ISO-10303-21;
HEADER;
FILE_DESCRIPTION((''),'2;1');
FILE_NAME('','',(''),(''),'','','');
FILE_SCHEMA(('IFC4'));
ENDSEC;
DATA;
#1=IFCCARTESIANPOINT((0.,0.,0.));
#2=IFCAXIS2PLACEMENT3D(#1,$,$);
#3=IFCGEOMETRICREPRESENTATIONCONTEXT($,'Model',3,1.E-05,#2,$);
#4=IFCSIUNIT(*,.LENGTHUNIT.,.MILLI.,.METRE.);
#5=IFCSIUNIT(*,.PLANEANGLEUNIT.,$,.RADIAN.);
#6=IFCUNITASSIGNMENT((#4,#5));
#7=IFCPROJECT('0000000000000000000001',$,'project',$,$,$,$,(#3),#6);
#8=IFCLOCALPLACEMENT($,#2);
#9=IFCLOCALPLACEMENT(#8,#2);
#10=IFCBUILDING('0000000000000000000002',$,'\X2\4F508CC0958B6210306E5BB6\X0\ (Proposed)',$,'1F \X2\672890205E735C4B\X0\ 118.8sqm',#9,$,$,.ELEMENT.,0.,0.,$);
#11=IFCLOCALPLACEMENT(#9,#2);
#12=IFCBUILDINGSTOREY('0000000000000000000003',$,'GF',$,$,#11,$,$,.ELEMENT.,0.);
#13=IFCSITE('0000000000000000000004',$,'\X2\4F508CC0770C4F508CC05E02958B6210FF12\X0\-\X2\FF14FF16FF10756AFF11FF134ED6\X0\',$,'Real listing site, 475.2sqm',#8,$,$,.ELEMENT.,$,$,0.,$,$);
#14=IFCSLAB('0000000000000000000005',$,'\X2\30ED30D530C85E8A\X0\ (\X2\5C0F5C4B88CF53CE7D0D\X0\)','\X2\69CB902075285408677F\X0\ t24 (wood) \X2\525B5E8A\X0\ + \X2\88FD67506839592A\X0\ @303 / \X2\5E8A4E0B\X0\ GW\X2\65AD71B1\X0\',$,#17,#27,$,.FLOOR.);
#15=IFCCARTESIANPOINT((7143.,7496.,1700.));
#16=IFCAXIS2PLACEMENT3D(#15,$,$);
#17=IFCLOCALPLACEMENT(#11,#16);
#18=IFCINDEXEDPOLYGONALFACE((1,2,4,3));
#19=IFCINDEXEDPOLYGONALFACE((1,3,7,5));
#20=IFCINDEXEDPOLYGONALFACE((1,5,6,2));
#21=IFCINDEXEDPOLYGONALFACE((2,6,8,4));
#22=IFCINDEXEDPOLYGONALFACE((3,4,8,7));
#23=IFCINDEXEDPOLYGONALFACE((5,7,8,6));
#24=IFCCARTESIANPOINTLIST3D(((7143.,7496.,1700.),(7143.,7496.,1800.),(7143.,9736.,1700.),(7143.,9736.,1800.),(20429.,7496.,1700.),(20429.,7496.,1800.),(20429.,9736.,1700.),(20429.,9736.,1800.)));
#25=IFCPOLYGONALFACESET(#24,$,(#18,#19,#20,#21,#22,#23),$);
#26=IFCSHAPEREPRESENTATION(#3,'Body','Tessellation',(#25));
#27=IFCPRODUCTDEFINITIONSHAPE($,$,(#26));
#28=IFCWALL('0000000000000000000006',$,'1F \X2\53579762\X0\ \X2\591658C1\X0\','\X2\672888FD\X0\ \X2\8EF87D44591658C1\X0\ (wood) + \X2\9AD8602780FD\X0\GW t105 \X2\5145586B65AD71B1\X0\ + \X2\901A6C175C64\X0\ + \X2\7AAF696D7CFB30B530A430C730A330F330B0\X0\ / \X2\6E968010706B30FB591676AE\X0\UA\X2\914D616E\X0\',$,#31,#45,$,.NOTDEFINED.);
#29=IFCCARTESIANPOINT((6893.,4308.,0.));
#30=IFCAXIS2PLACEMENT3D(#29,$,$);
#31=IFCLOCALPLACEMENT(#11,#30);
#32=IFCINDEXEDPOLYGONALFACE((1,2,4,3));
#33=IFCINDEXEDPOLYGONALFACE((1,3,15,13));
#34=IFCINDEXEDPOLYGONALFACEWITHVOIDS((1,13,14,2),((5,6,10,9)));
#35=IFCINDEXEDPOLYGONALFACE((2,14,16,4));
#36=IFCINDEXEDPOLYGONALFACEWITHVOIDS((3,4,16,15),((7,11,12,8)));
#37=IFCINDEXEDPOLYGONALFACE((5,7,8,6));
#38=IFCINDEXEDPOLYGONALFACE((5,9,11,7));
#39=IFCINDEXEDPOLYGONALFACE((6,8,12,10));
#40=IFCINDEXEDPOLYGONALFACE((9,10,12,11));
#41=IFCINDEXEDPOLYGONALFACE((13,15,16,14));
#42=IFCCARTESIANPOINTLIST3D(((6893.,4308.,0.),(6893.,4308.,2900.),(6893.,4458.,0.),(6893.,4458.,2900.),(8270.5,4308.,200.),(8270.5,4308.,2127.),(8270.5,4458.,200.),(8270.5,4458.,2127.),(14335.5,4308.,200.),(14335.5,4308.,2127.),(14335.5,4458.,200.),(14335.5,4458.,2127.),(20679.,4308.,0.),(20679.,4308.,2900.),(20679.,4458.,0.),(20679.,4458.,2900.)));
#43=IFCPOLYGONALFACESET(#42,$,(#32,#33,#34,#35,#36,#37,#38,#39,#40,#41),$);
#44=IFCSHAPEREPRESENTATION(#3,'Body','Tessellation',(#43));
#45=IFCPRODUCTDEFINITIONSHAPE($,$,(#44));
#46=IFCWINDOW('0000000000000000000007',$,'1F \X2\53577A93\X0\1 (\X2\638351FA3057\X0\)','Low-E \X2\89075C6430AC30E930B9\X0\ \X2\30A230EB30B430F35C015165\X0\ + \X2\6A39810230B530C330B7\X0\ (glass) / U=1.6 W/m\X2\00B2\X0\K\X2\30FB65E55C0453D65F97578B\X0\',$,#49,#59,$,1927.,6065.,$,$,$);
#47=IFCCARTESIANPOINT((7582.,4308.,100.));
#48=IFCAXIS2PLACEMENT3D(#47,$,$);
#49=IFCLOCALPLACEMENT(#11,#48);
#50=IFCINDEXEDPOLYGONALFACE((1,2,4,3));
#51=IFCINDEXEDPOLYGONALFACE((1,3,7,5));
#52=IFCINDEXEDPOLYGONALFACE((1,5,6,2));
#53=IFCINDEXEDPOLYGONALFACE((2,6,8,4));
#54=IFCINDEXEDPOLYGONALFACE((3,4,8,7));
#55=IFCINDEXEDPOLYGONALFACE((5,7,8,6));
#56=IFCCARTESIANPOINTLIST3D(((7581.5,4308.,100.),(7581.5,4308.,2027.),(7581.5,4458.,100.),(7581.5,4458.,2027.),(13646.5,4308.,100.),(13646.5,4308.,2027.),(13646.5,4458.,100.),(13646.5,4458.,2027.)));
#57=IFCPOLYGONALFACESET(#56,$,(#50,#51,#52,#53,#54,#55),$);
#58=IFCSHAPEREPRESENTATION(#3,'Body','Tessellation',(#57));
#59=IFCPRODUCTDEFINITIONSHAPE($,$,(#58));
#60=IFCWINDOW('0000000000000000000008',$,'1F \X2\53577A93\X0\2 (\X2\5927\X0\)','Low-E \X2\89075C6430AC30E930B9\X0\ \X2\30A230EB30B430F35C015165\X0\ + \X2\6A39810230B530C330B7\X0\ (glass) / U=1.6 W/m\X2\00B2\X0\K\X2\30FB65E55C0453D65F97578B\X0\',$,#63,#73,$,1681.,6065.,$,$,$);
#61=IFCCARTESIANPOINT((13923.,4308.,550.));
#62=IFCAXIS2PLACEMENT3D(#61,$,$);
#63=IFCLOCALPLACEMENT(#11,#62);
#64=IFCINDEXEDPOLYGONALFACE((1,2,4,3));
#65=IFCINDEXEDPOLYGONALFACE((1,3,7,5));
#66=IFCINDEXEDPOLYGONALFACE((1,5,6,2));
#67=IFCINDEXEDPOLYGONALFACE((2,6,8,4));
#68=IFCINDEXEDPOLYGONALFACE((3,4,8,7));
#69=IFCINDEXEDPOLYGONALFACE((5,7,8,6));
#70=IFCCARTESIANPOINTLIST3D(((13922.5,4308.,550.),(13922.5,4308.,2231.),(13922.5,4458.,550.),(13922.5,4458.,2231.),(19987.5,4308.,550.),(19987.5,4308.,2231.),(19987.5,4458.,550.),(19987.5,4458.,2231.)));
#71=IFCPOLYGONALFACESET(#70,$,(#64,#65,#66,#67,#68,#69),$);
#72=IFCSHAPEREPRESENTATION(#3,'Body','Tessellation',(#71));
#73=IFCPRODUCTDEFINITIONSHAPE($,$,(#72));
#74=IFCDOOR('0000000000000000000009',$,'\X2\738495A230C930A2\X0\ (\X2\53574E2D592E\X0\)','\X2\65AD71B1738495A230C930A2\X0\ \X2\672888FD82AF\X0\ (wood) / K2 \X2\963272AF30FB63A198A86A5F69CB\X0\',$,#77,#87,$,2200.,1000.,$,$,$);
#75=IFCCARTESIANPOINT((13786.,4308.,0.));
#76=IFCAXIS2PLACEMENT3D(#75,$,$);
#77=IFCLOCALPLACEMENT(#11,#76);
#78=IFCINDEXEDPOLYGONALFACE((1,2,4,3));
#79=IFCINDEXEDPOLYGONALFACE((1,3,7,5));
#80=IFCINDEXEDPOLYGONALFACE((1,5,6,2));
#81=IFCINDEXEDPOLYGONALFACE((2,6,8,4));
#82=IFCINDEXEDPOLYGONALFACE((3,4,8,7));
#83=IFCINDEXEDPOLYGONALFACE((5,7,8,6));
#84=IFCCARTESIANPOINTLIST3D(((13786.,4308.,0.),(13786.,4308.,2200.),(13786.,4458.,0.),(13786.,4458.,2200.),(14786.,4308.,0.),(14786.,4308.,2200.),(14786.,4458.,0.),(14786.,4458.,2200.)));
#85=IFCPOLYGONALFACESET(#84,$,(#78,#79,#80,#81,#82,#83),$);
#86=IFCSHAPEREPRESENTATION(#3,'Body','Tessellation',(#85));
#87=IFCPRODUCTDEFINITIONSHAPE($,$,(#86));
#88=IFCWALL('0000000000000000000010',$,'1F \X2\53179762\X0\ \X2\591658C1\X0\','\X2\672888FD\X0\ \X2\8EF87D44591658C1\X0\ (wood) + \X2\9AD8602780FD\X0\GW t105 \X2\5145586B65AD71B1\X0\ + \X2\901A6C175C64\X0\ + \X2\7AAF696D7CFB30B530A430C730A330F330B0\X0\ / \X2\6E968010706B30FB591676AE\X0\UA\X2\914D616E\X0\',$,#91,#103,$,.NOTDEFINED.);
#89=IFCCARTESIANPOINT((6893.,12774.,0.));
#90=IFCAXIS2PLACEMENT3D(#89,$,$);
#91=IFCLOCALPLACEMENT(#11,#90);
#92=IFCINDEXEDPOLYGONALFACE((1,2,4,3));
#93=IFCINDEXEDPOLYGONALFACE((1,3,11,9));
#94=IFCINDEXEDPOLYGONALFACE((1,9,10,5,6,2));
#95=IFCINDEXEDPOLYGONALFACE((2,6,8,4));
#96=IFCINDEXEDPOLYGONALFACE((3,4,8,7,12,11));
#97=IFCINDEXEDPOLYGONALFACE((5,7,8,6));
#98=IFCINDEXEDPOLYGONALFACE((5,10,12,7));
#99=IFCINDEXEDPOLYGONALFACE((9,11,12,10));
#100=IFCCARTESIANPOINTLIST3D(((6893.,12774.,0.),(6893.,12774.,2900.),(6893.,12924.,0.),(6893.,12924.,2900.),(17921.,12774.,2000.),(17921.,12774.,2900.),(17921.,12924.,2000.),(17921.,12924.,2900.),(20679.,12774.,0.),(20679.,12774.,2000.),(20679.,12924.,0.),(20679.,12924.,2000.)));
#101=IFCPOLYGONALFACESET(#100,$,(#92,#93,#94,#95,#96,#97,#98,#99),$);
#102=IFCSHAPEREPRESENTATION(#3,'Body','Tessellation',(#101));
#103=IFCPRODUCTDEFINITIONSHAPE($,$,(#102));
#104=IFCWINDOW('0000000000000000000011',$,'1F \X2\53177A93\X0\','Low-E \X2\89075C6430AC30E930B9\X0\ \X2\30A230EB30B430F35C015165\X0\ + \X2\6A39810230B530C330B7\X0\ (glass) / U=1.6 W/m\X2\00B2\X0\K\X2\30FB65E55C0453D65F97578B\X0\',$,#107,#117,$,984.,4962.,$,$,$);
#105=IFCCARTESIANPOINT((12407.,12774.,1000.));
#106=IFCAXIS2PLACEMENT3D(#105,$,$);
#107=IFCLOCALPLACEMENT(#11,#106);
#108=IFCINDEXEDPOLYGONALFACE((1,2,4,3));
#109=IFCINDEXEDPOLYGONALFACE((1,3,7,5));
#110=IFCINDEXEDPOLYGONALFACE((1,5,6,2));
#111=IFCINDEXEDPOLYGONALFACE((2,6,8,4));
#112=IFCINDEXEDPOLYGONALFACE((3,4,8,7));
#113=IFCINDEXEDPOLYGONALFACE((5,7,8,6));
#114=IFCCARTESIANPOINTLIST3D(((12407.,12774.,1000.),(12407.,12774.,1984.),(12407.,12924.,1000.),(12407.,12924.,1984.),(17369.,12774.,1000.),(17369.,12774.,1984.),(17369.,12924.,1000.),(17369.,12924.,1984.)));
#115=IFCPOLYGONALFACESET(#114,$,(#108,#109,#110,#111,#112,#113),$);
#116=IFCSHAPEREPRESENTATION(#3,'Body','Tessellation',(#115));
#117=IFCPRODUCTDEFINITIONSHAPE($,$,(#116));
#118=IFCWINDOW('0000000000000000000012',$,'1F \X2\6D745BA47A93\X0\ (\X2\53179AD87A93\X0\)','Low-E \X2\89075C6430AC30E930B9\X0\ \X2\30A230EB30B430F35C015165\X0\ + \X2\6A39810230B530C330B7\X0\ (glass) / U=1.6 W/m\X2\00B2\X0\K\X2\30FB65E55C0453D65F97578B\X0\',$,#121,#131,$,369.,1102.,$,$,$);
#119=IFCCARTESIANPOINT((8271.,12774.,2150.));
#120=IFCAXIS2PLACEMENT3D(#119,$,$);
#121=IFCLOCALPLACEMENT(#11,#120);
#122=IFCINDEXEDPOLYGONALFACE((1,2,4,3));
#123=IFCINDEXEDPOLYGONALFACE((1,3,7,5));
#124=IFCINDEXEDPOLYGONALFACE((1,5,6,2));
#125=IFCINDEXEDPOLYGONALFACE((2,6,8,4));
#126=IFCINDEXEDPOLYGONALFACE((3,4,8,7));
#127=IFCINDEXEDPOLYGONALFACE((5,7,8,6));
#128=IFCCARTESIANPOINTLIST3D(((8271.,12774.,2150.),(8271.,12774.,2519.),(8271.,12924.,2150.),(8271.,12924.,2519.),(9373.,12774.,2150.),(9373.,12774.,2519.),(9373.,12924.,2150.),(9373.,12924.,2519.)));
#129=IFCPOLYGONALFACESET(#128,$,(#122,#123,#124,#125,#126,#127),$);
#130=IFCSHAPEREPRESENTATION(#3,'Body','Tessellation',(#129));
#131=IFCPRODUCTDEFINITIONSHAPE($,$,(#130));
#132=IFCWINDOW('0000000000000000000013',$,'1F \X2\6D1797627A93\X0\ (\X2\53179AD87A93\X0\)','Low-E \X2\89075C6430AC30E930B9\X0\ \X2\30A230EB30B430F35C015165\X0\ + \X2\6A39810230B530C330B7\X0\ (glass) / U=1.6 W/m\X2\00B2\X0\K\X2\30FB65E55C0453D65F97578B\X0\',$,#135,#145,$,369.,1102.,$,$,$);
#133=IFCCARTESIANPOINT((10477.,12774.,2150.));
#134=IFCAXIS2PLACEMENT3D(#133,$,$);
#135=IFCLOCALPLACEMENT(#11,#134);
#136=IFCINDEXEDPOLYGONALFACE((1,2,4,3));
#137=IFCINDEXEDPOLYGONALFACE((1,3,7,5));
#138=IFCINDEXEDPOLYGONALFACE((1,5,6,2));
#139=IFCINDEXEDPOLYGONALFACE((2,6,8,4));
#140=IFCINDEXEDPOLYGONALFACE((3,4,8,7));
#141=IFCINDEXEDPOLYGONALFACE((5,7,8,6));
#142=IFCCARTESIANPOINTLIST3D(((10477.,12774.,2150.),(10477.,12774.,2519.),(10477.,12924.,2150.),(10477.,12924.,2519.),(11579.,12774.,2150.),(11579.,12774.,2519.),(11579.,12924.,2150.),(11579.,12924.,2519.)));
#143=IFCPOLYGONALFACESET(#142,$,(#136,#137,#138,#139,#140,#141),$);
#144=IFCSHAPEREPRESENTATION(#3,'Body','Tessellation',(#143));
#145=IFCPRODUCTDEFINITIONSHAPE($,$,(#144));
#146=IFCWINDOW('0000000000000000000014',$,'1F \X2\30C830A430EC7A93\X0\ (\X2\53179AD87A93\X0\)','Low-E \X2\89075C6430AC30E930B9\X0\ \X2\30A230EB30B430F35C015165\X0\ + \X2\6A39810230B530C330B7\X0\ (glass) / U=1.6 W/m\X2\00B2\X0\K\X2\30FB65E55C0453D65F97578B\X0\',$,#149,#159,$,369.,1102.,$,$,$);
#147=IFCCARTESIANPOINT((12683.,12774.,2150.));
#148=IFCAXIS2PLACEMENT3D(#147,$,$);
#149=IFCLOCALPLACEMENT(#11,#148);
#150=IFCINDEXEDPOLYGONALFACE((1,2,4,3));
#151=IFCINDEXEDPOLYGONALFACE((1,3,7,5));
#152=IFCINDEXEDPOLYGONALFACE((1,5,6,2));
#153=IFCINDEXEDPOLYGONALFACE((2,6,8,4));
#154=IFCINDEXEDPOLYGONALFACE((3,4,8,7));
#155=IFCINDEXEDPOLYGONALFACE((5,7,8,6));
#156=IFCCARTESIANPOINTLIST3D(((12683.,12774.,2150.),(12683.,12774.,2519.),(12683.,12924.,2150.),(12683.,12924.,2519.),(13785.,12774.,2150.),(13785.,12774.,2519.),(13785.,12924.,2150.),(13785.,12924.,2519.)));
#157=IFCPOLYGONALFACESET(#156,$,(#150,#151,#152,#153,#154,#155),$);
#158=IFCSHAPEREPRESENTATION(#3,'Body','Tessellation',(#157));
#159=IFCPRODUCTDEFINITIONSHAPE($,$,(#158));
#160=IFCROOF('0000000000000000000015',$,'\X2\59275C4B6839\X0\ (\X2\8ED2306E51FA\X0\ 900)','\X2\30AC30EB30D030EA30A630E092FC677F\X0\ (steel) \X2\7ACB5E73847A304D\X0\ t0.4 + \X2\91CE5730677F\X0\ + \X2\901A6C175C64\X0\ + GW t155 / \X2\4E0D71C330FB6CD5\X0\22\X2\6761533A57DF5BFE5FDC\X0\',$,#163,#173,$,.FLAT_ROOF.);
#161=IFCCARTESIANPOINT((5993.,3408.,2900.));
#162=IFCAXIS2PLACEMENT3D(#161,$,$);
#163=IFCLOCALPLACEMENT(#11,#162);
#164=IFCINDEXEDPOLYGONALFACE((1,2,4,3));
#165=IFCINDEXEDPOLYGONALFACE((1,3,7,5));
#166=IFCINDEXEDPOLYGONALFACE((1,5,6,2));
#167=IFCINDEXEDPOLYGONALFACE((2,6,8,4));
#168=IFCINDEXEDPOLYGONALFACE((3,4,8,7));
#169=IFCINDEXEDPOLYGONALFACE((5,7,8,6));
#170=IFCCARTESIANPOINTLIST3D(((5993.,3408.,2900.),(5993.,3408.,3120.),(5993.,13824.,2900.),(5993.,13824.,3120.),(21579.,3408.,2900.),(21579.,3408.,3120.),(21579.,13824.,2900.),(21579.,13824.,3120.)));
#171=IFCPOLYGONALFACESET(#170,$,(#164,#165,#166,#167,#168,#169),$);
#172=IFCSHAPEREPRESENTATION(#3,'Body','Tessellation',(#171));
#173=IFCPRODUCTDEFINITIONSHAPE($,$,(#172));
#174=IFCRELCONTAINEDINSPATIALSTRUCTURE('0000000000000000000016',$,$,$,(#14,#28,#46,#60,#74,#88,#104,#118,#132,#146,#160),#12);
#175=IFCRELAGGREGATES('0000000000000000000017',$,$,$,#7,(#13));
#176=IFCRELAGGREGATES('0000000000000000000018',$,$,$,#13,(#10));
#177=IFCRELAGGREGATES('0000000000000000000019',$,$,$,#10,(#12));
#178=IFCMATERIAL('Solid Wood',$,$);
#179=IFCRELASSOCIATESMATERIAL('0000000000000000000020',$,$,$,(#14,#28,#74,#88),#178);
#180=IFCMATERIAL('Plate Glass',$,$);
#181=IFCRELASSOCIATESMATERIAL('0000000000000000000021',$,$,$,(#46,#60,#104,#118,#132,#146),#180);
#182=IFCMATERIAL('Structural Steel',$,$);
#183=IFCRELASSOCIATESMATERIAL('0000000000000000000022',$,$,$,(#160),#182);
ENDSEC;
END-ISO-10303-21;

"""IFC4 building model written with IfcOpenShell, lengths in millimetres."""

from ifc_helpers import new_model, si_unit, frame, frame_2d, origin, place, context, project, spatial, rectangle, extrude, material, element, fill, save


model = new_model("IFC4")

# Units and contexts
model_context = context("Model", 3, precision=1e-05, world=origin())
ifc_project = project(units=[si_unit("LENGTHUNIT", "METRE", prefix="MILLI"), si_unit("PLANEANGLEUNIT", "RADIAN")], contexts=[model_context])

# Site, building, storey
site_placement = place(None, origin())
site = spatial("IfcSite", under=ifc_project, at=site_placement, Name="佐賀県佐賀市開成２-４６０番１３他", ObjectType="Real listing site, 475.2sqm", CompositionType="ELEMENT", RefElevation=0.0)
building_placement = place(site_placement, origin())
building = spatial("IfcBuilding", under=site, at=building_placement, Name="佐賀開成の家 (Proposed)", ObjectType="1F 木造平屋 118.8sqm", CompositionType="ELEMENT", ElevationOfRefHeight=0.0, ElevationOfTerrain=0.0)
storey_placement = place(building_placement, origin())
storey = spatial("IfcBuildingStorey", under=building, at=storey_placement, Name="GF", CompositionType="ELEMENT", Elevation=0.0)

# Slab
ifc_material_1 = material(Name="Solid Wood")
slab_1_placement = place(storey_placement, frame((7143.0, 7496.0, 1700.0)))
element("IfcSlab", 1, at=slab_1_placement, inside=storey, material=ifc_material_1, Name="ロフト床 (小屋裏収納)", Description="構造用合板 t24 (wood) 剛床 + 製材根太 @303 / 床下 GW断熱", PredefinedType="FLOOR", context=model_context, shape_type="SweptSolid", body=[
    extrude(rectangle(XDim=13286.0, YDim=2240.0, at=frame_2d((6643.0, 1120.0))), frame((7143.0, 7496.0, 1700.0)), (0.0, 0.0, 1.0), 100.0),
])

# Wall, openings, windows, door
wall_1_placement = place(storey_placement, frame((6893.0, 4308.0, 0.0)))
wall_1 = element("IfcWall", 2, at=wall_1_placement, inside=storey, material=ifc_material_1, Name="1F 南面 外壁", Description="木製 軸組外壁 (wood) + 高性能GW t105 充填断熱 + 通気層 + 窯業系サイディング / 準耐火・外皮UA配慮", PredefinedType="NOTDEFINED", context=model_context, shape_type="SweptSolid", body=[
    extrude(rectangle(XDim=13786.0, YDim=150.0, at=frame_2d((6893.0, 75.0))), frame((6893.0, 4308.0, 0.0)), (0.0, 0.0, 1.0), 2900.0),
])
opening_1_placement = place(storey_placement, frame((7582.0, 4308.0, 100.0)))
opening_1 = element("IfcOpeningElement", 3, at=opening_1_placement, cuts=wall_1, PredefinedType="NOTDEFINED", context=model_context, shape_type="SweptSolid", body=[
    extrude(rectangle(XDim=6065.0, YDim=150.0, at=frame_2d((3032.0, 75.0))), frame((7582.0, 4308.0, 100.0)), (0.0, 0.0, 1.0), 1927.0),
])
opening_2_placement = place(storey_placement, frame((13923.0, 4308.0, 550.0)))
opening_2 = element("IfcOpeningElement", 4, at=opening_2_placement, cuts=wall_1, PredefinedType="NOTDEFINED", context=model_context, shape_type="SweptSolid", body=[
    extrude(rectangle(XDim=6065.0, YDim=150.0, at=frame_2d((3032.0, 75.0))), frame((13923.0, 4308.0, 550.0)), (0.0, 0.0, 1.0), 1681.0),
])
opening_3_placement = place(storey_placement, frame((13786.0, 4308.0, 0.0)))
opening_3 = element("IfcOpeningElement", 5, at=opening_3_placement, cuts=wall_1, PredefinedType="NOTDEFINED", context=model_context, shape_type="SweptSolid", body=[
    extrude(rectangle(XDim=1000.0, YDim=150.0, at=frame_2d((500.0, 75.0))), frame((13786.0, 4308.0, 0.0)), (0.0, 0.0, 1.0), 2200.0),
])
ifc_material_2 = material(Name="Plate Glass")
window_1_placement = place(storey_placement, frame((7582.0, 4308.0, 100.0)))
window_1 = element("IfcWindow", 6, at=window_1_placement, inside=storey, material=ifc_material_2, Name="1F 南窓1 (掃出し)", Description="Low-E 複層ガラス アルゴン封入 + 樹脂サッシ (glass) / U=1.6 W/m²K・日射取得型", OverallHeight=1927.0, OverallWidth=6065.0, context=model_context, shape_type="SweptSolid", body=[
    extrude(rectangle(XDim=6065.0, YDim=150.0, at=frame_2d((3032.0, 75.0))), frame((7582.0, 4308.0, 100.0)), (0.0, 0.0, 1.0), 1927.0),
])
fill(opening_1, window_1)
window_2_placement = place(storey_placement, frame((13923.0, 4308.0, 550.0)))
window_2 = element("IfcWindow", 7, at=window_2_placement, inside=storey, material=ifc_material_2, Name="1F 南窓2 (大)", Description="Low-E 複層ガラス アルゴン封入 + 樹脂サッシ (glass) / U=1.6 W/m²K・日射取得型", OverallHeight=1681.0, OverallWidth=6065.0, context=model_context, shape_type="SweptSolid", body=[
    extrude(rectangle(XDim=6065.0, YDim=150.0, at=frame_2d((3032.0, 75.0))), frame((13923.0, 4308.0, 550.0)), (0.0, 0.0, 1.0), 1681.0),
])
fill(opening_2, window_2)
door_1_placement = place(storey_placement, frame((13786.0, 4308.0, 0.0)))
door_1 = element("IfcDoor", 8, at=door_1_placement, inside=storey, material=ifc_material_1, Name="玄関ドア (南中央)", Description="断熱玄関ドア 木製芯 (wood) / K2 防犯・採風機構", OverallHeight=2200.0, OverallWidth=1000.0, context=model_context, shape_type="SweptSolid", body=[
    extrude(rectangle(XDim=1000.0, YDim=150.0, at=frame_2d((500.0, 75.0))), frame((13786.0, 4308.0, 0.0)), (0.0, 0.0, 1.0), 2200.0),
])
fill(opening_3, door_1)

# Wall, openings, windows
wall_2_placement = place(storey_placement, frame((6893.0, 12774.0, 0.0)))
wall_2 = element("IfcWall", 9, at=wall_2_placement, inside=storey, material=ifc_material_1, Name="1F 北面 外壁", Description="木製 軸組外壁 (wood) + 高性能GW t105 充填断熱 + 通気層 + 窯業系サイディング / 準耐火・外皮UA配慮", PredefinedType="NOTDEFINED", context=model_context, shape_type="SweptSolid", body=[
    extrude(rectangle(XDim=13786.0, YDim=150.0, at=frame_2d((6893.0, 75.0))), frame((6893.0, 12774.0, 0.0)), (0.0, 0.0, 1.0), 2900.0),
])
opening_4_placement = place(storey_placement, frame((12407.0, 12774.0, 1000.0)))
opening_4 = element("IfcOpeningElement", 10, at=opening_4_placement, cuts=wall_2, PredefinedType="NOTDEFINED", context=model_context, shape_type="SweptSolid", body=[
    extrude(rectangle(XDim=4962.0, YDim=150.0, at=frame_2d((2481.0, 75.0))), frame((12407.0, 12774.0, 1000.0)), (0.0, 0.0, 1.0), 984.0),
])
opening_5_placement = place(storey_placement, frame((8271.0, 12774.0, 2150.0)))
opening_5 = element("IfcOpeningElement", 11, at=opening_5_placement, cuts=wall_2, PredefinedType="NOTDEFINED", context=model_context, shape_type="SweptSolid", body=[
    extrude(rectangle(XDim=1102.0, YDim=150.0, at=frame_2d((551.0, 75.0))), frame((8271.0, 12774.0, 2150.0)), (0.0, 0.0, 1.0), 369.0),
])
opening_6_placement = place(storey_placement, frame((10477.0, 12774.0, 2150.0)))
opening_6 = element("IfcOpeningElement", 12, at=opening_6_placement, cuts=wall_2, PredefinedType="NOTDEFINED", context=model_context, shape_type="SweptSolid", body=[
    extrude(rectangle(XDim=1102.0, YDim=150.0, at=frame_2d((551.0, 75.0))), frame((10477.0, 12774.0, 2150.0)), (0.0, 0.0, 1.0), 369.0),
])
opening_7_placement = place(storey_placement, frame((12683.0, 12774.0, 2150.0)))
opening_7 = element("IfcOpeningElement", 13, at=opening_7_placement, cuts=wall_2, PredefinedType="NOTDEFINED", context=model_context, shape_type="SweptSolid", body=[
    extrude(rectangle(XDim=1102.0, YDim=150.0, at=frame_2d((551.0, 75.0))), frame((12683.0, 12774.0, 2150.0)), (0.0, 0.0, 1.0), 369.0),
])
window_3_placement = place(storey_placement, frame((12407.0, 12774.0, 1000.0)))
window_3 = element("IfcWindow", 14, at=window_3_placement, inside=storey, material=ifc_material_2, Name="1F 北窓", Description="Low-E 複層ガラス アルゴン封入 + 樹脂サッシ (glass) / U=1.6 W/m²K・日射取得型", OverallHeight=984.0, OverallWidth=4962.0, context=model_context, shape_type="SweptSolid", body=[
    extrude(rectangle(XDim=4962.0, YDim=150.0, at=frame_2d((2481.0, 75.0))), frame((12407.0, 12774.0, 1000.0)), (0.0, 0.0, 1.0), 984.0),
])
fill(opening_4, window_3)
window_4_placement = place(storey_placement, frame((8271.0, 12774.0, 2150.0)))
window_4 = element("IfcWindow", 15, at=window_4_placement, inside=storey, material=ifc_material_2, Name="1F 浴室窓 (北高窓)", Description="Low-E 複層ガラス アルゴン封入 + 樹脂サッシ (glass) / U=1.6 W/m²K・日射取得型", OverallHeight=369.0, OverallWidth=1102.0, context=model_context, shape_type="SweptSolid", body=[
    extrude(rectangle(XDim=1102.0, YDim=150.0, at=frame_2d((551.0, 75.0))), frame((8271.0, 12774.0, 2150.0)), (0.0, 0.0, 1.0), 369.0),
])
fill(opening_5, window_4)
window_5_placement = place(storey_placement, frame((10477.0, 12774.0, 2150.0)))
window_5 = element("IfcWindow", 16, at=window_5_placement, inside=storey, material=ifc_material_2, Name="1F 洗面窓 (北高窓)", Description="Low-E 複層ガラス アルゴン封入 + 樹脂サッシ (glass) / U=1.6 W/m²K・日射取得型", OverallHeight=369.0, OverallWidth=1102.0, context=model_context, shape_type="SweptSolid", body=[
    extrude(rectangle(XDim=1102.0, YDim=150.0, at=frame_2d((551.0, 75.0))), frame((10477.0, 12774.0, 2150.0)), (0.0, 0.0, 1.0), 369.0),
])
fill(opening_6, window_5)
window_6_placement = place(storey_placement, frame((12683.0, 12774.0, 2150.0)))
window_6 = element("IfcWindow", 17, at=window_6_placement, inside=storey, material=ifc_material_2, Name="1F トイレ窓 (北高窓)", Description="Low-E 複層ガラス アルゴン封入 + 樹脂サッシ (glass) / U=1.6 W/m²K・日射取得型", OverallHeight=369.0, OverallWidth=1102.0, context=model_context, shape_type="SweptSolid", body=[
    extrude(rectangle(XDim=1102.0, YDim=150.0, at=frame_2d((551.0, 75.0))), frame((12683.0, 12774.0, 2150.0)), (0.0, 0.0, 1.0), 369.0),
])
fill(opening_7, window_6)

# Roof
ifc_material_3 = material(Name="Structural Steel")
roof_placement = place(storey_placement, frame((5993.0, 3408.0, 2900.0)))
element("IfcRoof", 18, at=roof_placement, inside=storey, material=ifc_material_3, Name="大屋根 (軒の出 900)", Description="ガルバリウム鋼板 (steel) 立平葺き t0.4 + 野地板 + 通気層 + GW t155 / 不燃・法22条区域対応", PredefinedType="FLAT_ROOF", context=model_context, shape_type="SweptSolid", body=[
    extrude(rectangle(XDim=15586.0, YDim=10416.0, at=frame_2d((7793.0, 5208.0))), frame((5993.0, 3408.0, 2900.0)), (0.0, 0.0, 1.0), 220.0),
])

save(model, "model.ifc")
